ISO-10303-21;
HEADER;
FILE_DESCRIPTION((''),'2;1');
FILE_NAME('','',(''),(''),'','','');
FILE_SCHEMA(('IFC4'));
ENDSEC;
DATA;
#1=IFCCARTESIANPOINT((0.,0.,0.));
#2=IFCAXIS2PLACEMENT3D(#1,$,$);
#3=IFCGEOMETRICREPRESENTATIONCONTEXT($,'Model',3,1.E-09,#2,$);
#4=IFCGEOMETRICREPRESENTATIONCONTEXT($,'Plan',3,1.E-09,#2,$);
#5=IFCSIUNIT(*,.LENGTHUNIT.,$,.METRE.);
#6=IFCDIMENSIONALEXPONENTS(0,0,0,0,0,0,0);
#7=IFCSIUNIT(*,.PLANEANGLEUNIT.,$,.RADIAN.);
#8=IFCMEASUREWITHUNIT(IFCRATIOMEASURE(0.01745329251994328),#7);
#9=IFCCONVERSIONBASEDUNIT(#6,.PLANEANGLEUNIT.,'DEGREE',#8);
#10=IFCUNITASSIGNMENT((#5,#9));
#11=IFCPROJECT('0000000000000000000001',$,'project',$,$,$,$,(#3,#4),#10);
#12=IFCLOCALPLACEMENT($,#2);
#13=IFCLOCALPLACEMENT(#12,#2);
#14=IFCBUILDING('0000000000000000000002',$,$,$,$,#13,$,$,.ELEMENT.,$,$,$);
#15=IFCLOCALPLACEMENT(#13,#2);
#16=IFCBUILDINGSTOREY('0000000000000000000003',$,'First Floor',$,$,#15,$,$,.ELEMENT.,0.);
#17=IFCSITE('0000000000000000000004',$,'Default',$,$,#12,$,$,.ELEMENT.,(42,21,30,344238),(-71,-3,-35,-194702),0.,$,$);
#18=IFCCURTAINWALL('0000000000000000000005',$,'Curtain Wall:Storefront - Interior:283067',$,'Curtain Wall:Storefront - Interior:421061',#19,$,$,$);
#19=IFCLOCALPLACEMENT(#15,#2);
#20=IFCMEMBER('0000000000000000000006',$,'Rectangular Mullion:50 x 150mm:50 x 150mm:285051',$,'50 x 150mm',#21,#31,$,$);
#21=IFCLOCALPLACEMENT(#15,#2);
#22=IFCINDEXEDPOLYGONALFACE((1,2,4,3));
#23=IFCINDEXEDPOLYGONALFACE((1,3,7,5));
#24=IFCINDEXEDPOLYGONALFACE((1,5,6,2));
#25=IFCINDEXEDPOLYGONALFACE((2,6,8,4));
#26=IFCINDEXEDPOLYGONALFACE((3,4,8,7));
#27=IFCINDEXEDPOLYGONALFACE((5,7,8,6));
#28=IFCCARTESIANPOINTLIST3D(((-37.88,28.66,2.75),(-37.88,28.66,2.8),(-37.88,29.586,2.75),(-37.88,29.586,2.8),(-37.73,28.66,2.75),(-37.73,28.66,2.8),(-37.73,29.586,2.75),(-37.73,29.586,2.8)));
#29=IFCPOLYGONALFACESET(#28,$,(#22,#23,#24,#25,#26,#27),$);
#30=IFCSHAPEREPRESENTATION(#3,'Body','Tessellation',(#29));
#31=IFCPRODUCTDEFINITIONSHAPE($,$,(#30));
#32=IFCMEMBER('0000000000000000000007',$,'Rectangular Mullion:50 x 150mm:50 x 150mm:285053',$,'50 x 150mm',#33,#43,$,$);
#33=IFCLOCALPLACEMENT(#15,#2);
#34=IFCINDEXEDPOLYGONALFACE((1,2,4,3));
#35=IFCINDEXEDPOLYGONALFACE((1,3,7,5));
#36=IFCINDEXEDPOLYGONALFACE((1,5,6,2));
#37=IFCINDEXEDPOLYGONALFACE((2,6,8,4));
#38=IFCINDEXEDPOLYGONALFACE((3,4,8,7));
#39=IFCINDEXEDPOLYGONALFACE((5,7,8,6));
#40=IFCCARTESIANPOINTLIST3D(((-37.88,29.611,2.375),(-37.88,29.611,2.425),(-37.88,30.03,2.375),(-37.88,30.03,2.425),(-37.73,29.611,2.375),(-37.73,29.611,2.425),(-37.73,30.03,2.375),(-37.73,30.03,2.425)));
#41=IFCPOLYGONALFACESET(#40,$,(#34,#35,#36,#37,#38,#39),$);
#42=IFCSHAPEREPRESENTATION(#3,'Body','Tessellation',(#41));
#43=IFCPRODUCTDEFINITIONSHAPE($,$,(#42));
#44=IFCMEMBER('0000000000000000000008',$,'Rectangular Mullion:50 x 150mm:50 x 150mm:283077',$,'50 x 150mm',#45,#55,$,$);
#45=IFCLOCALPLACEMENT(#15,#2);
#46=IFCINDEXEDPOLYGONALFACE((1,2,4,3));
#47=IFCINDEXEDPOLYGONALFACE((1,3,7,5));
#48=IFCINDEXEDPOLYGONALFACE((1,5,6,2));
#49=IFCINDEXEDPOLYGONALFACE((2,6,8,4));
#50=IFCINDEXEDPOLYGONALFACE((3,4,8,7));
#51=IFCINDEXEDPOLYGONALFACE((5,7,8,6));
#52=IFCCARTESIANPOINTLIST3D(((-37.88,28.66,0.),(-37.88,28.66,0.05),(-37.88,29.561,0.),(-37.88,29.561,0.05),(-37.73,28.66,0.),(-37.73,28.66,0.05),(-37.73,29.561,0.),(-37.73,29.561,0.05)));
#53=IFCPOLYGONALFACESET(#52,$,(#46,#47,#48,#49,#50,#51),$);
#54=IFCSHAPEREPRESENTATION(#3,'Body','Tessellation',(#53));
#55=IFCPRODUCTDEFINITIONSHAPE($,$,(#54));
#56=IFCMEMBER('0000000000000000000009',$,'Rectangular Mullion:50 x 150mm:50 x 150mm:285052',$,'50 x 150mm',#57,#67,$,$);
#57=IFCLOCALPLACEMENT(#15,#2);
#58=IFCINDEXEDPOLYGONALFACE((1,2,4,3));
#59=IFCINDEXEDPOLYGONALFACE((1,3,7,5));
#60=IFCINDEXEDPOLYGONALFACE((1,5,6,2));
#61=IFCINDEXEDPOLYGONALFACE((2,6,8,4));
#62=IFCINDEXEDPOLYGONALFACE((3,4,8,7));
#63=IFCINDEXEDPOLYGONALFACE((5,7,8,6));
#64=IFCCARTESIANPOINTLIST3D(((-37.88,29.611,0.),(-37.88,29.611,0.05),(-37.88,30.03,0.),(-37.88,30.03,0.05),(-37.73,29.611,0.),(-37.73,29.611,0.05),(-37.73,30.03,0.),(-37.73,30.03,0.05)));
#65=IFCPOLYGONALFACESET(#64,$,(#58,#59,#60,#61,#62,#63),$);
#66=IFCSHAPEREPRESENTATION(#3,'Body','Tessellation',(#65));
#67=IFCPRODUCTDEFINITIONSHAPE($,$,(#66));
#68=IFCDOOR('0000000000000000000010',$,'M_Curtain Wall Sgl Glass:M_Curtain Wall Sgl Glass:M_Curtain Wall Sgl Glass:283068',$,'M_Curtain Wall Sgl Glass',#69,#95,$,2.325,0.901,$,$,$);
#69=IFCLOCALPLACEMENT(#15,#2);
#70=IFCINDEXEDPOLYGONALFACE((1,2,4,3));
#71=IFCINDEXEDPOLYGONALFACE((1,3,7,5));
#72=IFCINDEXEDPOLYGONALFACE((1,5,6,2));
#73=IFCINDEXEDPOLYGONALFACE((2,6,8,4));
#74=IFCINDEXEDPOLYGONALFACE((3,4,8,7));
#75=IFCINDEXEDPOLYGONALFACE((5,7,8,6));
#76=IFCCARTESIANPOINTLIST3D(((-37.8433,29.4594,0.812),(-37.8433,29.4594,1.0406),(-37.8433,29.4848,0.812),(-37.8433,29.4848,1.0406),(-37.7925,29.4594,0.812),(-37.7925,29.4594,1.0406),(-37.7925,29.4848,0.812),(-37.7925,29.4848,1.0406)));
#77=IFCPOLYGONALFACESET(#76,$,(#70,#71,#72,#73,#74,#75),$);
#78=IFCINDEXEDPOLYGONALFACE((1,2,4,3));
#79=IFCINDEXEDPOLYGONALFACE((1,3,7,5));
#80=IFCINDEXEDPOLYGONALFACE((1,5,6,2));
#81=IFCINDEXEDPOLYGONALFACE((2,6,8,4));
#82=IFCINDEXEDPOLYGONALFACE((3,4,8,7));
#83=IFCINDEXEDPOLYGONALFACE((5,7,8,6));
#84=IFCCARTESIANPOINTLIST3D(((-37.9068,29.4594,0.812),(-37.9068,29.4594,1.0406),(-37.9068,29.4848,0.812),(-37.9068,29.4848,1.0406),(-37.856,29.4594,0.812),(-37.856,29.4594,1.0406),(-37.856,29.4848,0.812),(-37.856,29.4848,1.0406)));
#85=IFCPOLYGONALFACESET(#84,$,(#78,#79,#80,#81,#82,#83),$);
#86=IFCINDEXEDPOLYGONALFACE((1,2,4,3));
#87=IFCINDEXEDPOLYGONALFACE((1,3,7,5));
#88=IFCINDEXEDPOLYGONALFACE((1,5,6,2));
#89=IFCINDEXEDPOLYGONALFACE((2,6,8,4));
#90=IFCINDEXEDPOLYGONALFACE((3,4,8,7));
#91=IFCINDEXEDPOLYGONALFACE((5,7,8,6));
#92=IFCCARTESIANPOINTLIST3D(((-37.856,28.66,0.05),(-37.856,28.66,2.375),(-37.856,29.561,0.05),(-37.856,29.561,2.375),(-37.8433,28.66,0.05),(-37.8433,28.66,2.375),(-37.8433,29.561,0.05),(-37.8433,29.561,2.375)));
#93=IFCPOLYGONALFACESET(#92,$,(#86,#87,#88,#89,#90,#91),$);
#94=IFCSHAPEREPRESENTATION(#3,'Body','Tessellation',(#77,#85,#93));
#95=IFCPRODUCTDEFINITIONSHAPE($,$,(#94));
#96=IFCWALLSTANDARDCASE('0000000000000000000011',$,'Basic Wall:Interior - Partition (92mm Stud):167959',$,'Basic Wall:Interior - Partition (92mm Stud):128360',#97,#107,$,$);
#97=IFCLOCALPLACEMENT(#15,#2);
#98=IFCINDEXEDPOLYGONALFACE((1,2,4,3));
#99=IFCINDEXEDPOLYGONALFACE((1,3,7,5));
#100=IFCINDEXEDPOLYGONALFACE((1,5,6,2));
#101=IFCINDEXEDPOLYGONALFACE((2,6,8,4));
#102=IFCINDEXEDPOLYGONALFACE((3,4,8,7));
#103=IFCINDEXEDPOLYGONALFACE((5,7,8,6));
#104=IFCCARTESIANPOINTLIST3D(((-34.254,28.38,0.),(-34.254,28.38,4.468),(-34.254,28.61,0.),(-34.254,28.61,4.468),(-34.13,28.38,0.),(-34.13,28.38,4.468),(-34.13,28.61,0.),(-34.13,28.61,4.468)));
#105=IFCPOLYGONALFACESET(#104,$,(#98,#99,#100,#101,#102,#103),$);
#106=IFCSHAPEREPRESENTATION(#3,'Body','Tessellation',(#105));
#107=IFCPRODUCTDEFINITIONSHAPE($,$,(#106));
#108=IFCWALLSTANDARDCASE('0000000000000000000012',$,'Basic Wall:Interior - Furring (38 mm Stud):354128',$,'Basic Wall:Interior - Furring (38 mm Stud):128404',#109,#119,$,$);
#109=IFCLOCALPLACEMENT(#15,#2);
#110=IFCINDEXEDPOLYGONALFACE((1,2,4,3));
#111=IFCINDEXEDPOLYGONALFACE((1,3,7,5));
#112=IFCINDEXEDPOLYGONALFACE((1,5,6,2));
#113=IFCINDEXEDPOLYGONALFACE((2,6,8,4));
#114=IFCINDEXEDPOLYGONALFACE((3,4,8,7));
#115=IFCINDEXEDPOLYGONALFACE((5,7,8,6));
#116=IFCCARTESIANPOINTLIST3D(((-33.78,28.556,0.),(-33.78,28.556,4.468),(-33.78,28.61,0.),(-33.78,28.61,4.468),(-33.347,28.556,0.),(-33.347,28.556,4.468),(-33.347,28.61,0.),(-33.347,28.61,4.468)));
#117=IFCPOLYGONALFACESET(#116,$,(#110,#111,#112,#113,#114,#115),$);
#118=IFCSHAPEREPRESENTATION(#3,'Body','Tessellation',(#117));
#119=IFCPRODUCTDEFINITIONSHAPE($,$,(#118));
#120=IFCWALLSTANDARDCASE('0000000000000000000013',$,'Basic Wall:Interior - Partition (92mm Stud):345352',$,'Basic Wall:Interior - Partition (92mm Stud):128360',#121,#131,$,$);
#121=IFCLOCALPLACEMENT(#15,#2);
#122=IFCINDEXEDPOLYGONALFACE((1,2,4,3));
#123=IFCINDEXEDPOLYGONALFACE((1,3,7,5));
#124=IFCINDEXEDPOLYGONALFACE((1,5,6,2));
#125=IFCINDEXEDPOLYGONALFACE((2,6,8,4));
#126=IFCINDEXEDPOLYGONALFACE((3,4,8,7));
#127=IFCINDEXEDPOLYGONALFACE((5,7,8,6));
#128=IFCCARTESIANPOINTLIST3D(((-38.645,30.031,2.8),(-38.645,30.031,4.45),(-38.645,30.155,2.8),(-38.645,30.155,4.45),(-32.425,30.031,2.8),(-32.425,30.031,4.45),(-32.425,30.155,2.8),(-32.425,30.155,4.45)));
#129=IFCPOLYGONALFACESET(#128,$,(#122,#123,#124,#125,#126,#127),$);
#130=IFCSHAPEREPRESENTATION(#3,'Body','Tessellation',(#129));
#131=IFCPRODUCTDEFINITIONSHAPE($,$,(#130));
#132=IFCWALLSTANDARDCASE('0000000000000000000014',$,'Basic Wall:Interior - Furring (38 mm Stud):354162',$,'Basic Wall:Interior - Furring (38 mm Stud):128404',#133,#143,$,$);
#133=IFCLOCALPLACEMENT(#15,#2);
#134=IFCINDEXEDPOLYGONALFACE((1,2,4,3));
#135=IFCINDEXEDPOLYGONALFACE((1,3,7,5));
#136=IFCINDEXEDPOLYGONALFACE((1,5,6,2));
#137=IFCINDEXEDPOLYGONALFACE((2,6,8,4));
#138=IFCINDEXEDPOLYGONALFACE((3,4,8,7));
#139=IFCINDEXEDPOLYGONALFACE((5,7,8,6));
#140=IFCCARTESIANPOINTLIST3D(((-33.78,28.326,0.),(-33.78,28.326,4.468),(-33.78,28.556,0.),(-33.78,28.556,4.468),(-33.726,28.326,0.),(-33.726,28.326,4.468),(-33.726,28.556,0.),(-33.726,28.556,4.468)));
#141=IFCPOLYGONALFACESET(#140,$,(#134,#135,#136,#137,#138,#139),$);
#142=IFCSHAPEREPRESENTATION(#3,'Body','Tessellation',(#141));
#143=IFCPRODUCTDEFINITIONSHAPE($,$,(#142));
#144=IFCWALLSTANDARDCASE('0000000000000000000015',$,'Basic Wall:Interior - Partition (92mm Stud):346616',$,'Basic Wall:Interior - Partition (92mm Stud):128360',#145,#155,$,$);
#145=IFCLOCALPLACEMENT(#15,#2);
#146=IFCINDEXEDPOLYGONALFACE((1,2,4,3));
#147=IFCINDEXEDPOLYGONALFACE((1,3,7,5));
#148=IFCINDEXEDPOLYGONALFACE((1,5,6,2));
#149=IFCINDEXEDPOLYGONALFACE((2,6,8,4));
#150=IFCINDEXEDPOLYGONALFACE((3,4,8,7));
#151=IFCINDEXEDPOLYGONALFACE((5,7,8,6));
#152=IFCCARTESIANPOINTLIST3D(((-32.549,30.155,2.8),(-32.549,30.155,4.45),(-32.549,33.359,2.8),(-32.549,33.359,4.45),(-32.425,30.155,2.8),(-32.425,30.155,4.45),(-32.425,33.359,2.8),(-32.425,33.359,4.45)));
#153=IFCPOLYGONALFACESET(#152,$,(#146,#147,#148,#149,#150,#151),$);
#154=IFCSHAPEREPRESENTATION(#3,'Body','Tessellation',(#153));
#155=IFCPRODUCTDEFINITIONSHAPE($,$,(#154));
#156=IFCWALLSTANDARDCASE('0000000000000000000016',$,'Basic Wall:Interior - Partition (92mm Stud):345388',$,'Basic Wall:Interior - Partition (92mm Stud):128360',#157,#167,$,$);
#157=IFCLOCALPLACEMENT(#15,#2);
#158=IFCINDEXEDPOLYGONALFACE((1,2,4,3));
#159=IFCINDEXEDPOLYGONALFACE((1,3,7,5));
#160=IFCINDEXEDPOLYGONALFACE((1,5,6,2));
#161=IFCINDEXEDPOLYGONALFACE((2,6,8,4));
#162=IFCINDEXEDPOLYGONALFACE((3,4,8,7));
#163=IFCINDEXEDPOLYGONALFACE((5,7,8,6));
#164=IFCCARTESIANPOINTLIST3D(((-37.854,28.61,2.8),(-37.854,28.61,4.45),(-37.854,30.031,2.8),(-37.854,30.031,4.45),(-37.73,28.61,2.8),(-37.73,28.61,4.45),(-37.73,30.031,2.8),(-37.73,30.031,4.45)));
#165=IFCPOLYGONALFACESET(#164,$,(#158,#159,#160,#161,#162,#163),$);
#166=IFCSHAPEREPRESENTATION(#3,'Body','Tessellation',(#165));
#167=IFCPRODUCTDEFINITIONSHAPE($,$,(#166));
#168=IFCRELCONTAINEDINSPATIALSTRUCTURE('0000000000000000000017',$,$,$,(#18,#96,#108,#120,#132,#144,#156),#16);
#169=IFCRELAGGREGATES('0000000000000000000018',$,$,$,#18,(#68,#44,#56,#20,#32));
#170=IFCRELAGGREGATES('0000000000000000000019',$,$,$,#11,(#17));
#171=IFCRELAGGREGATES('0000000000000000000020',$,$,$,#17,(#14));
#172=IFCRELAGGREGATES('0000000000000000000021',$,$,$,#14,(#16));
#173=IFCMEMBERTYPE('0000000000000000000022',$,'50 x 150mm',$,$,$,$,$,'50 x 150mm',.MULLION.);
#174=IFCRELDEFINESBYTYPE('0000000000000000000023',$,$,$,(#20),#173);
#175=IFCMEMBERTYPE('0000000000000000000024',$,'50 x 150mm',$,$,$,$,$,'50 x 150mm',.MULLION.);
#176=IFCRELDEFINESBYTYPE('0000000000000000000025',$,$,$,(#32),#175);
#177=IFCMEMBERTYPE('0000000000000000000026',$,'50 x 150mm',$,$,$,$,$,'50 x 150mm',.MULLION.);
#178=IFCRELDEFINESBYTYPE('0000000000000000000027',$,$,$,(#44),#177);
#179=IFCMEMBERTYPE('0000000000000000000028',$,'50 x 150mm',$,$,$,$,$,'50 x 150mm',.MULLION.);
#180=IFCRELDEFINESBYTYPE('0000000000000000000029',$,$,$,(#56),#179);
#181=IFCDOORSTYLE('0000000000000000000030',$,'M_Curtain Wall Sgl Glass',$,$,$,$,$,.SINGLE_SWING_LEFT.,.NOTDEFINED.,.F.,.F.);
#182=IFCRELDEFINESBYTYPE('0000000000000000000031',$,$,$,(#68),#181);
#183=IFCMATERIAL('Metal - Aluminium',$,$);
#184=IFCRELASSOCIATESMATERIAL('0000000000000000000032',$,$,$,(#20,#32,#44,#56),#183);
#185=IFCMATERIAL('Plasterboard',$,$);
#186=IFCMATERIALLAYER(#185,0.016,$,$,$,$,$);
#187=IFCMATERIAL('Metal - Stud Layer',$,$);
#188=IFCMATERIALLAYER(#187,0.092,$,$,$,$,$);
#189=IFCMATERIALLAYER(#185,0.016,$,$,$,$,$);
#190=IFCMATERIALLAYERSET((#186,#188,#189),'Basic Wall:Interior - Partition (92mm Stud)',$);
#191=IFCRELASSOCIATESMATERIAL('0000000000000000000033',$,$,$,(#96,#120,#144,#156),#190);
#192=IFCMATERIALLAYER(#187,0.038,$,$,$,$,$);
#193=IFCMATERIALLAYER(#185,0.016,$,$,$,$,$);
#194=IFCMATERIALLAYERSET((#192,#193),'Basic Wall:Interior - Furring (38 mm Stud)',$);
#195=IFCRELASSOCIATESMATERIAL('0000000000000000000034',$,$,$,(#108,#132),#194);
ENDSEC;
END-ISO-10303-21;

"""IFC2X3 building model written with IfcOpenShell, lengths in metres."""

from ifc_helpers import new_model, entity, si_unit, converted_unit, frame, frame_2d, origin, origin_2d_with_axis, place, context, project, spatial, rectangle, extrude, source, transform, mapped, material, layer, layer_set, layer_usage, type_object, type_shapes, element, aggregate, save


model = new_model("IFC2X3")

# Units and contexts
model_context = context("Model", 3, precision=1e-09, world=origin())
plan_context = context("Plan", 3, precision=1e-09, world=origin())
ifc_project = project(units=[si_unit("LENGTHUNIT", "METRE"), converted_unit("PLANEANGLEUNIT", "DEGREE", entity("IfcRatioMeasure", 0.01745329251994328), si_unit("PLANEANGLEUNIT", "RADIAN"), dimensions=[0, 0, 0, 0, 0, 0, 0])], contexts=[model_context, plan_context])

# Site, building, storey
site_placement = place(None, origin())
site = spatial("IfcSite", under=ifc_project, at=site_placement, Name="Default", CompositionType="ELEMENT", RefLatitude=(42, 21, 30, 344238), RefLongitude=(-71, -3, -35, -194702), RefElevation=0.0)
building_placement = place(site_placement, origin())
building = spatial("IfcBuilding", under=site, at=building_placement, CompositionType="ELEMENT")
storey_placement = place(building_placement, origin())
storey = spatial("IfcBuildingStorey", under=building, at=storey_placement, Name="First Floor", CompositionType="ELEMENT", Elevation=0.0)

# Curtain wall
curtain_wall_1_placement = place(storey_placement, origin())
curtain_wall_1 = element("IfcCurtainWall", 1, at=curtain_wall_1_placement, inside=storey, Name="Curtain Wall:Storefront - Interior:283067", ObjectType="Curtain Wall:Storefront - Interior:421061")
ifc_material_1 = material(Name="Metal - Aluminium")

# Members
member_type_1 = type_object("IfcMemberType", Name="50 x 150mm", ElementType="50 x 150mm", PredefinedType="MULLION")
shared_shape_1 = source(origin(), model_context, "Body", "SweptSolid", [
    extrude(rectangle(XDim=0.05, YDim=0.15, at=origin_2d_with_axis()), frame((-0.025, 0.0, -0.926), z_axis=(0.0, 0.0, 1.0), x_axis=(-1.0, 0.0, 0.0)), (0.0, 0.0, 1.0), 0.926),
])
type_shapes(member_type_1, [shared_shape_1])
member_1_placement = place(storey_placement, frame((-37.805, 29.586, 2.8), z_axis=(0.0, 1.0, 0.0), x_axis=(0.0, 0.0, 1.0)))
member_1 = element("IfcMember", 2, at=member_1_placement, type_object=member_type_1, material=ifc_material_1, Name="Rectangular Mullion:50 x 150mm:50 x 150mm:285051", ObjectType="50 x 150mm", context=model_context, shape_type="MappedRepresentation", body=[
    mapped(shared_shape_1, transform((0.0, 0.0, 0.0), scale=1.0)),
])
member_type_2 = type_object("IfcMemberType", Name="50 x 150mm", ElementType="50 x 150mm", PredefinedType="MULLION")
shared_shape_2 = source(origin(), model_context, "Body", "SweptSolid", [
    extrude(rectangle(XDim=0.05, YDim=0.15, at=origin_2d_with_axis()), frame((0.0, 0.0, -0.419), z_axis=(0.0, 0.0, 1.0), x_axis=(-1.0, 0.0, 0.0)), (0.0, 0.0, 1.0), 0.419),
])
type_shapes(member_type_2, [shared_shape_2])
member_2_placement = place(storey_placement, frame((-37.805, 30.03, 2.4), z_axis=(0.0, 1.0, 0.0), x_axis=(0.0, 0.0, 1.0)))
member_2 = element("IfcMember", 3, at=member_2_placement, type_object=member_type_2, material=ifc_material_1, Name="Rectangular Mullion:50 x 150mm:50 x 150mm:285053", ObjectType="50 x 150mm", context=model_context, shape_type="MappedRepresentation", body=[
    mapped(shared_shape_2, transform((0.0, 0.0, 0.0), scale=1.0)),
])
member_type_3 = type_object("IfcMemberType", Name="50 x 150mm", ElementType="50 x 150mm", PredefinedType="MULLION")
shared_shape_3 = source(origin(), model_context, "Body", "SweptSolid", [
    extrude(rectangle(XDim=0.05, YDim=0.15, at=origin_2d_with_axis()), frame((-0.025, 0.0, -0.901), z_axis=(0.0, 0.0, 1.0), x_axis=(-1.0, 0.0, 0.0)), (0.0, 0.0, 1.0), 0.901),
])
type_shapes(member_type_3, [shared_shape_3])
member_3_placement = place(storey_placement, frame((-37.805, 28.66, 0.0), z_axis=(0.0, -1.0, 0.0), x_axis=(0.0, 0.0, -1.0)))
member_3 = element("IfcMember", 4, at=member_3_placement, type_object=member_type_3, material=ifc_material_1, Name="Rectangular Mullion:50 x 150mm:50 x 150mm:283077", ObjectType="50 x 150mm", context=model_context, shape_type="MappedRepresentation", body=[
    mapped(shared_shape_3, transform((0.0, 0.0, 0.0), scale=1.0)),
])
member_type_4 = type_object("IfcMemberType", Name="50 x 150mm", ElementType="50 x 150mm", PredefinedType="MULLION")
shared_shape_4 = source(origin(), model_context, "Body", "SweptSolid", [
    extrude(rectangle(XDim=0.05, YDim=0.15, at=origin_2d_with_axis()), frame((-0.025, 0.0, -0.419), z_axis=(0.0, 0.0, 1.0), x_axis=(-1.0, 0.0, 0.0)), (0.0, 0.0, 1.0), 0.419),
])
type_shapes(member_type_4, [shared_shape_4])
member_4_placement = place(storey_placement, frame((-37.805, 29.611, 0.0), z_axis=(0.0, -1.0, 0.0), x_axis=(0.0, 0.0, -1.0)))
member_4 = element("IfcMember", 5, at=member_4_placement, type_object=member_type_4, material=ifc_material_1, Name="Rectangular Mullion:50 x 150mm:50 x 150mm:285052", ObjectType="50 x 150mm", context=model_context, shape_type="MappedRepresentation", body=[
    mapped(shared_shape_4, transform((0.0, 0.0, 0.0), scale=1.0)),
])

# Door
door_style = type_object("IfcDoorStyle", Name="M_Curtain Wall Sgl Glass", ConstructionType="NOTDEFINED", OperationType="SINGLE_SWING_LEFT", ParameterTakesPrecedence=False, Sizeable=False)
shared_shape_5 = source(origin(), model_context, "Body", "SweptSolid", [
    extrude(rectangle(XDim=0.0254, YDim=0.0508, at=origin_2d_with_axis()), frame((-0.3616, -0.0129, 0.762), z_axis=(0.0, 0.0, 1.0), x_axis=(-1.0, 0.0, 0.0)), (0.0, 0.0, 1.0), 0.2286),
    extrude(rectangle(XDim=0.0254, YDim=0.0508, at=origin_2d_with_axis()), frame((-0.3616, -0.0764, 0.762)), (0.0, 0.0, 1.0), 0.2286),
    extrude(rectangle(XDim=0.0127, YDim=0.901, at=origin_2d_with_axis()), frame((0.0, -0.0447, 0.0), z_axis=(0.0, 0.0, 1.0), x_axis=(0.0, 1.0, 0.0)), (0.0, 0.0, 1.0), 2.325),
])
type_shapes(door_style, [shared_shape_5])
door_1_placement = place(storey_placement, frame((-37.805, 29.1105, 0.05), z_axis=(0.0, 0.0, 1.0), x_axis=(0.0, -1.0, 0.0)))
door_1 = element("IfcDoor", 6, at=door_1_placement, type_object=door_style, Name="M_Curtain Wall Sgl Glass:M_Curtain Wall Sgl Glass:M_Curtain Wall Sgl Glass:283068", ObjectType="M_Curtain Wall Sgl Glass", OverallHeight=2.325, OverallWidth=0.901, context=model_context, shape_type="MappedRepresentation", body=[
    mapped(shared_shape_5, transform((0.0, 0.0, 0.0), scale=1.0)),
])
aggregate(curtain_wall_1, [door_1, member_3, member_4, member_1, member_2])

# Walls
ifc_material_2 = material(Name="Plasterboard")
ifc_layer_1 = layer(ifc_material_2, 0.016)
ifc_material_3 = material(Name="Metal - Stud Layer")
ifc_layer_2 = layer(ifc_material_3, 0.092)
ifc_layer_3 = layer(ifc_material_2, 0.016)
ifc_layer_set_1 = layer_set([ifc_layer_1, ifc_layer_2, ifc_layer_3], Name="Basic Wall:Interior - Partition (92mm Stud)")
ifc_layer_usage_1 = layer_usage(ifc_layer_set_1, "AXIS2", "NEGATIVE", 0.062)
wall_1_placement = place(storey_placement, frame((-34.192, 28.61, 0.0), z_axis=(0.0, 0.0, 1.0), x_axis=(0.0, -1.0, 0.0)))
element("IfcWallStandardCase", 7, at=wall_1_placement, inside=storey, material=ifc_layer_usage_1, Name="Basic Wall:Interior - Partition (92mm Stud):167959", ObjectType="Basic Wall:Interior - Partition (92mm Stud):128360", context=model_context, shape_type="SweptSolid", body=[
    extrude(rectangle(XDim=0.23, YDim=0.124, at=frame_2d((0.115, 0.0), x_axis=(-1.0, 0.0))), origin(), (0.0, 0.0, 1.0), 4.468),
])
ifc_layer_4 = layer(ifc_material_3, 0.038)
ifc_layer_5 = layer(ifc_material_2, 0.016)
ifc_layer_set_2 = layer_set([ifc_layer_4, ifc_layer_5], Name="Basic Wall:Interior - Furring (38 mm Stud)")
ifc_layer_usage_2 = layer_usage(ifc_layer_set_2, "AXIS2", "NEGATIVE", 0.027)
wall_2_placement = place(storey_placement, frame((-33.347, 28.583, 0.0), z_axis=(0.0, 0.0, 1.0), x_axis=(-1.0, 0.0, 0.0)))
element("IfcWallStandardCase", 8, at=wall_2_placement, inside=storey, material=ifc_layer_usage_2, Name="Basic Wall:Interior - Furring (38 mm Stud):354128", ObjectType="Basic Wall:Interior - Furring (38 mm Stud):128404", context=model_context, shape_type="SweptSolid", body=[
    extrude(rectangle(XDim=0.433, YDim=0.054, at=frame_2d((0.2165, 0.0), x_axis=(-1.0, 0.0))), origin(), (0.0, 0.0, 1.0), 4.468),
])
wall_3_placement = place(storey_placement, frame((-38.645, 30.093, 2.8)))
element("IfcWallStandardCase", 9, at=wall_3_placement, inside=storey, material=ifc_layer_usage_1, Name="Basic Wall:Interior - Partition (92mm Stud):345352", ObjectType="Basic Wall:Interior - Partition (92mm Stud):128360", context=model_context, shape_type="SweptSolid", body=[
    extrude(rectangle(XDim=6.22, YDim=0.124, at=frame_2d((3.11, 0.0), x_axis=(-1.0, 0.0))), origin(), (0.0, 0.0, 1.0), 1.65),
])
wall_4_placement = place(storey_placement, frame((-33.753, 28.556, 0.0), z_axis=(0.0, 0.0, 1.0), x_axis=(0.0, -1.0, 0.0)))
element("IfcWallStandardCase", 10, at=wall_4_placement, inside=storey, material=ifc_layer_usage_2, Name="Basic Wall:Interior - Furring (38 mm Stud):354162", ObjectType="Basic Wall:Interior - Furring (38 mm Stud):128404", context=model_context, shape_type="SweptSolid", body=[
    extrude(rectangle(XDim=0.23, YDim=0.054, at=frame_2d((0.115, 0.0), x_axis=(-1.0, 0.0))), origin(), (0.0, 0.0, 1.0), 4.468),
])
wall_5_placement = place(storey_placement, frame((-32.487, 30.155, 2.8), z_axis=(0.0, 0.0, 1.0), x_axis=(0.0, 1.0, 0.0)))
element("IfcWallStandardCase", 11, at=wall_5_placement, inside=storey, material=ifc_layer_usage_1, Name="Basic Wall:Interior - Partition (92mm Stud):346616", ObjectType="Basic Wall:Interior - Partition (92mm Stud):128360", context=model_context, shape_type="SweptSolid", body=[
    extrude(rectangle(XDim=3.204, YDim=0.124, at=frame_2d((1.602, 0.0), x_axis=(-1.0, 0.0))), origin(), (0.0, 0.0, 1.0), 1.65),
])
wall_6_placement = place(storey_placement, frame((-37.792, 30.031, 2.8), z_axis=(0.0, 0.0, 1.0), x_axis=(0.0, -1.0, 0.0)))
element("IfcWallStandardCase", 12, at=wall_6_placement, inside=storey, material=ifc_layer_usage_1, Name="Basic Wall:Interior - Partition (92mm Stud):345388", ObjectType="Basic Wall:Interior - Partition (92mm Stud):128360", context=model_context, shape_type="SweptSolid", body=[
    extrude(rectangle(XDim=1.421, YDim=0.124, at=frame_2d((0.7105, 0.0), x_axis=(-1.0, 0.0))), origin(), (0.0, 0.0, 1.0), 1.65),
])

save(model, "model.ifc")
